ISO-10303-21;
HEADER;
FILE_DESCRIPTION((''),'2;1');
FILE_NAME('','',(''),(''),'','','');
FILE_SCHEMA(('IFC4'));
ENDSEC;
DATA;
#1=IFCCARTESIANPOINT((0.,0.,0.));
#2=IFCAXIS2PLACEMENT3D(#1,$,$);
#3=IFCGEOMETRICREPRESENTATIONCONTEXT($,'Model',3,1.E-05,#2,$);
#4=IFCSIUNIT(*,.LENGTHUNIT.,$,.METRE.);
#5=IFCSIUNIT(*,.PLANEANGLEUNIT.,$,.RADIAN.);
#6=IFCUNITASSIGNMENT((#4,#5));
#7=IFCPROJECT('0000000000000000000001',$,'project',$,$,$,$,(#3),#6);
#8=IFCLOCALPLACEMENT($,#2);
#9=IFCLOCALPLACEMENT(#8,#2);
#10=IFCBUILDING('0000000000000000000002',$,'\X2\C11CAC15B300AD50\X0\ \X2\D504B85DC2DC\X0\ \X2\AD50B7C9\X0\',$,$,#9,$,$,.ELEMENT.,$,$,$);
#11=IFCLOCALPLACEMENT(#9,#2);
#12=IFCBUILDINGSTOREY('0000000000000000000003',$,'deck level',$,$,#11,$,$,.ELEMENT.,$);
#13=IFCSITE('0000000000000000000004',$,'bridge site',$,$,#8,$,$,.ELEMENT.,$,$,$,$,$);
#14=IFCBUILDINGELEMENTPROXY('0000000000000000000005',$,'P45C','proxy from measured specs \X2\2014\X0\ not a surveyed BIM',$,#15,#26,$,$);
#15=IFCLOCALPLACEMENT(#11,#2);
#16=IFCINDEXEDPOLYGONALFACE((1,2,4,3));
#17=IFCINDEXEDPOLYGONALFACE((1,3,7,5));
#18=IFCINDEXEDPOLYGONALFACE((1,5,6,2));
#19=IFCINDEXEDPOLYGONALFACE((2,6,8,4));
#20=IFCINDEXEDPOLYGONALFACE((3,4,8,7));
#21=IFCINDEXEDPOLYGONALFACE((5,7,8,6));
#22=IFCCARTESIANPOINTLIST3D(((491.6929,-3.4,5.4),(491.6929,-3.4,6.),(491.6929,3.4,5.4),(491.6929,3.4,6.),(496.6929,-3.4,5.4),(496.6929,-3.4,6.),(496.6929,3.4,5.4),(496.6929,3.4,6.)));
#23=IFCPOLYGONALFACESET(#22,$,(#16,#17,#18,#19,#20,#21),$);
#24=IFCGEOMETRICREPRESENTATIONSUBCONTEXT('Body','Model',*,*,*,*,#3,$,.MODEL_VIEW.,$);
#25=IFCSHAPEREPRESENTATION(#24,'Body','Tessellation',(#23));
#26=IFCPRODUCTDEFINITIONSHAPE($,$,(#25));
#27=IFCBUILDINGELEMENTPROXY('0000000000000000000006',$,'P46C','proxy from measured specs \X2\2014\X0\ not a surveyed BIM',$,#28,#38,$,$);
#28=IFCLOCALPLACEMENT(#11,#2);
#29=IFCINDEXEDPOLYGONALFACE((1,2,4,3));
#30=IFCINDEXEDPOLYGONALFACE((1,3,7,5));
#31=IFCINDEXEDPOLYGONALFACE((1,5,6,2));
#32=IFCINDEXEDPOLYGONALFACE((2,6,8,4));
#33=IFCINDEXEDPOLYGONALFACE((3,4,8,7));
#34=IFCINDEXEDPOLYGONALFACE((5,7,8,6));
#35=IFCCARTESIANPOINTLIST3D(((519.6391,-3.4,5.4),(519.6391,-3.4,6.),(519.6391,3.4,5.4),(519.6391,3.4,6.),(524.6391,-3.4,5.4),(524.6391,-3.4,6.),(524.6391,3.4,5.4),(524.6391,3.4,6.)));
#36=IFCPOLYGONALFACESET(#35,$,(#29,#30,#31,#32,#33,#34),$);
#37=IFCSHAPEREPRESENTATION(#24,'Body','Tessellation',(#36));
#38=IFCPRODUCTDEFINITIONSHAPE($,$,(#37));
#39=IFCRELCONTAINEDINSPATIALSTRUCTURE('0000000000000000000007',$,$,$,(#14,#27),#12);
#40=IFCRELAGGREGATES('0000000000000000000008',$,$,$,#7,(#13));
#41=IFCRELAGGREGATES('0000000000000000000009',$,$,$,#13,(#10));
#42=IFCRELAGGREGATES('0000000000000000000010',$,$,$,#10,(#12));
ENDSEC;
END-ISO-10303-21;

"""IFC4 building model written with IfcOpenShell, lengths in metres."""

from ifc_helpers import new_model, si_unit, frame, origin, origin_2d, place, context, subcontext, project, spatial, rectangle, extrude, element, save


model = new_model("IFC4")

# Units and contexts
model_context = context("Model", 3, precision=1e-05, world=origin())
body_context = subcontext(model_context, "Body", "Model", "MODEL_VIEW")
ifc_project = project(units=[si_unit("LENGTHUNIT", "METRE"), si_unit("PLANEANGLEUNIT", "RADIAN")], contexts=[model_context])

# Site, building, storey
site_placement = place(None, origin())
site = spatial("IfcSite", under=ifc_project, at=site_placement, Name="bridge site", CompositionType="ELEMENT")
building_placement = place(site_placement, origin())
building = spatial("IfcBuilding", under=site, at=building_placement, Name="서강대교 프록시 교량", CompositionType="ELEMENT")
storey_placement = place(building_placement, origin())
storey = spatial("IfcBuildingStorey", under=building, at=storey_placement, Name="deck level", CompositionType="ELEMENT")

# Building element proxies
for number, where, name in (
    (1, (494.1929, 0.0, 5.4), "P45C"),
    (2, (522.1391, 0.0, 5.4), "P46C"),
):
    element("IfcBuildingElementProxy", number, at=place(storey_placement, frame(where)), inside=storey, Name=name, Description="proxy from measured specs — not a surveyed BIM", context=body_context, shape_type="SweptSolid", body=[
        extrude(rectangle(XDim=5.0, YDim=6.8, at=origin_2d()), origin(), (0.0, 0.0, 1.0), 0.6),
    ])

save(model, "model.ifc")
